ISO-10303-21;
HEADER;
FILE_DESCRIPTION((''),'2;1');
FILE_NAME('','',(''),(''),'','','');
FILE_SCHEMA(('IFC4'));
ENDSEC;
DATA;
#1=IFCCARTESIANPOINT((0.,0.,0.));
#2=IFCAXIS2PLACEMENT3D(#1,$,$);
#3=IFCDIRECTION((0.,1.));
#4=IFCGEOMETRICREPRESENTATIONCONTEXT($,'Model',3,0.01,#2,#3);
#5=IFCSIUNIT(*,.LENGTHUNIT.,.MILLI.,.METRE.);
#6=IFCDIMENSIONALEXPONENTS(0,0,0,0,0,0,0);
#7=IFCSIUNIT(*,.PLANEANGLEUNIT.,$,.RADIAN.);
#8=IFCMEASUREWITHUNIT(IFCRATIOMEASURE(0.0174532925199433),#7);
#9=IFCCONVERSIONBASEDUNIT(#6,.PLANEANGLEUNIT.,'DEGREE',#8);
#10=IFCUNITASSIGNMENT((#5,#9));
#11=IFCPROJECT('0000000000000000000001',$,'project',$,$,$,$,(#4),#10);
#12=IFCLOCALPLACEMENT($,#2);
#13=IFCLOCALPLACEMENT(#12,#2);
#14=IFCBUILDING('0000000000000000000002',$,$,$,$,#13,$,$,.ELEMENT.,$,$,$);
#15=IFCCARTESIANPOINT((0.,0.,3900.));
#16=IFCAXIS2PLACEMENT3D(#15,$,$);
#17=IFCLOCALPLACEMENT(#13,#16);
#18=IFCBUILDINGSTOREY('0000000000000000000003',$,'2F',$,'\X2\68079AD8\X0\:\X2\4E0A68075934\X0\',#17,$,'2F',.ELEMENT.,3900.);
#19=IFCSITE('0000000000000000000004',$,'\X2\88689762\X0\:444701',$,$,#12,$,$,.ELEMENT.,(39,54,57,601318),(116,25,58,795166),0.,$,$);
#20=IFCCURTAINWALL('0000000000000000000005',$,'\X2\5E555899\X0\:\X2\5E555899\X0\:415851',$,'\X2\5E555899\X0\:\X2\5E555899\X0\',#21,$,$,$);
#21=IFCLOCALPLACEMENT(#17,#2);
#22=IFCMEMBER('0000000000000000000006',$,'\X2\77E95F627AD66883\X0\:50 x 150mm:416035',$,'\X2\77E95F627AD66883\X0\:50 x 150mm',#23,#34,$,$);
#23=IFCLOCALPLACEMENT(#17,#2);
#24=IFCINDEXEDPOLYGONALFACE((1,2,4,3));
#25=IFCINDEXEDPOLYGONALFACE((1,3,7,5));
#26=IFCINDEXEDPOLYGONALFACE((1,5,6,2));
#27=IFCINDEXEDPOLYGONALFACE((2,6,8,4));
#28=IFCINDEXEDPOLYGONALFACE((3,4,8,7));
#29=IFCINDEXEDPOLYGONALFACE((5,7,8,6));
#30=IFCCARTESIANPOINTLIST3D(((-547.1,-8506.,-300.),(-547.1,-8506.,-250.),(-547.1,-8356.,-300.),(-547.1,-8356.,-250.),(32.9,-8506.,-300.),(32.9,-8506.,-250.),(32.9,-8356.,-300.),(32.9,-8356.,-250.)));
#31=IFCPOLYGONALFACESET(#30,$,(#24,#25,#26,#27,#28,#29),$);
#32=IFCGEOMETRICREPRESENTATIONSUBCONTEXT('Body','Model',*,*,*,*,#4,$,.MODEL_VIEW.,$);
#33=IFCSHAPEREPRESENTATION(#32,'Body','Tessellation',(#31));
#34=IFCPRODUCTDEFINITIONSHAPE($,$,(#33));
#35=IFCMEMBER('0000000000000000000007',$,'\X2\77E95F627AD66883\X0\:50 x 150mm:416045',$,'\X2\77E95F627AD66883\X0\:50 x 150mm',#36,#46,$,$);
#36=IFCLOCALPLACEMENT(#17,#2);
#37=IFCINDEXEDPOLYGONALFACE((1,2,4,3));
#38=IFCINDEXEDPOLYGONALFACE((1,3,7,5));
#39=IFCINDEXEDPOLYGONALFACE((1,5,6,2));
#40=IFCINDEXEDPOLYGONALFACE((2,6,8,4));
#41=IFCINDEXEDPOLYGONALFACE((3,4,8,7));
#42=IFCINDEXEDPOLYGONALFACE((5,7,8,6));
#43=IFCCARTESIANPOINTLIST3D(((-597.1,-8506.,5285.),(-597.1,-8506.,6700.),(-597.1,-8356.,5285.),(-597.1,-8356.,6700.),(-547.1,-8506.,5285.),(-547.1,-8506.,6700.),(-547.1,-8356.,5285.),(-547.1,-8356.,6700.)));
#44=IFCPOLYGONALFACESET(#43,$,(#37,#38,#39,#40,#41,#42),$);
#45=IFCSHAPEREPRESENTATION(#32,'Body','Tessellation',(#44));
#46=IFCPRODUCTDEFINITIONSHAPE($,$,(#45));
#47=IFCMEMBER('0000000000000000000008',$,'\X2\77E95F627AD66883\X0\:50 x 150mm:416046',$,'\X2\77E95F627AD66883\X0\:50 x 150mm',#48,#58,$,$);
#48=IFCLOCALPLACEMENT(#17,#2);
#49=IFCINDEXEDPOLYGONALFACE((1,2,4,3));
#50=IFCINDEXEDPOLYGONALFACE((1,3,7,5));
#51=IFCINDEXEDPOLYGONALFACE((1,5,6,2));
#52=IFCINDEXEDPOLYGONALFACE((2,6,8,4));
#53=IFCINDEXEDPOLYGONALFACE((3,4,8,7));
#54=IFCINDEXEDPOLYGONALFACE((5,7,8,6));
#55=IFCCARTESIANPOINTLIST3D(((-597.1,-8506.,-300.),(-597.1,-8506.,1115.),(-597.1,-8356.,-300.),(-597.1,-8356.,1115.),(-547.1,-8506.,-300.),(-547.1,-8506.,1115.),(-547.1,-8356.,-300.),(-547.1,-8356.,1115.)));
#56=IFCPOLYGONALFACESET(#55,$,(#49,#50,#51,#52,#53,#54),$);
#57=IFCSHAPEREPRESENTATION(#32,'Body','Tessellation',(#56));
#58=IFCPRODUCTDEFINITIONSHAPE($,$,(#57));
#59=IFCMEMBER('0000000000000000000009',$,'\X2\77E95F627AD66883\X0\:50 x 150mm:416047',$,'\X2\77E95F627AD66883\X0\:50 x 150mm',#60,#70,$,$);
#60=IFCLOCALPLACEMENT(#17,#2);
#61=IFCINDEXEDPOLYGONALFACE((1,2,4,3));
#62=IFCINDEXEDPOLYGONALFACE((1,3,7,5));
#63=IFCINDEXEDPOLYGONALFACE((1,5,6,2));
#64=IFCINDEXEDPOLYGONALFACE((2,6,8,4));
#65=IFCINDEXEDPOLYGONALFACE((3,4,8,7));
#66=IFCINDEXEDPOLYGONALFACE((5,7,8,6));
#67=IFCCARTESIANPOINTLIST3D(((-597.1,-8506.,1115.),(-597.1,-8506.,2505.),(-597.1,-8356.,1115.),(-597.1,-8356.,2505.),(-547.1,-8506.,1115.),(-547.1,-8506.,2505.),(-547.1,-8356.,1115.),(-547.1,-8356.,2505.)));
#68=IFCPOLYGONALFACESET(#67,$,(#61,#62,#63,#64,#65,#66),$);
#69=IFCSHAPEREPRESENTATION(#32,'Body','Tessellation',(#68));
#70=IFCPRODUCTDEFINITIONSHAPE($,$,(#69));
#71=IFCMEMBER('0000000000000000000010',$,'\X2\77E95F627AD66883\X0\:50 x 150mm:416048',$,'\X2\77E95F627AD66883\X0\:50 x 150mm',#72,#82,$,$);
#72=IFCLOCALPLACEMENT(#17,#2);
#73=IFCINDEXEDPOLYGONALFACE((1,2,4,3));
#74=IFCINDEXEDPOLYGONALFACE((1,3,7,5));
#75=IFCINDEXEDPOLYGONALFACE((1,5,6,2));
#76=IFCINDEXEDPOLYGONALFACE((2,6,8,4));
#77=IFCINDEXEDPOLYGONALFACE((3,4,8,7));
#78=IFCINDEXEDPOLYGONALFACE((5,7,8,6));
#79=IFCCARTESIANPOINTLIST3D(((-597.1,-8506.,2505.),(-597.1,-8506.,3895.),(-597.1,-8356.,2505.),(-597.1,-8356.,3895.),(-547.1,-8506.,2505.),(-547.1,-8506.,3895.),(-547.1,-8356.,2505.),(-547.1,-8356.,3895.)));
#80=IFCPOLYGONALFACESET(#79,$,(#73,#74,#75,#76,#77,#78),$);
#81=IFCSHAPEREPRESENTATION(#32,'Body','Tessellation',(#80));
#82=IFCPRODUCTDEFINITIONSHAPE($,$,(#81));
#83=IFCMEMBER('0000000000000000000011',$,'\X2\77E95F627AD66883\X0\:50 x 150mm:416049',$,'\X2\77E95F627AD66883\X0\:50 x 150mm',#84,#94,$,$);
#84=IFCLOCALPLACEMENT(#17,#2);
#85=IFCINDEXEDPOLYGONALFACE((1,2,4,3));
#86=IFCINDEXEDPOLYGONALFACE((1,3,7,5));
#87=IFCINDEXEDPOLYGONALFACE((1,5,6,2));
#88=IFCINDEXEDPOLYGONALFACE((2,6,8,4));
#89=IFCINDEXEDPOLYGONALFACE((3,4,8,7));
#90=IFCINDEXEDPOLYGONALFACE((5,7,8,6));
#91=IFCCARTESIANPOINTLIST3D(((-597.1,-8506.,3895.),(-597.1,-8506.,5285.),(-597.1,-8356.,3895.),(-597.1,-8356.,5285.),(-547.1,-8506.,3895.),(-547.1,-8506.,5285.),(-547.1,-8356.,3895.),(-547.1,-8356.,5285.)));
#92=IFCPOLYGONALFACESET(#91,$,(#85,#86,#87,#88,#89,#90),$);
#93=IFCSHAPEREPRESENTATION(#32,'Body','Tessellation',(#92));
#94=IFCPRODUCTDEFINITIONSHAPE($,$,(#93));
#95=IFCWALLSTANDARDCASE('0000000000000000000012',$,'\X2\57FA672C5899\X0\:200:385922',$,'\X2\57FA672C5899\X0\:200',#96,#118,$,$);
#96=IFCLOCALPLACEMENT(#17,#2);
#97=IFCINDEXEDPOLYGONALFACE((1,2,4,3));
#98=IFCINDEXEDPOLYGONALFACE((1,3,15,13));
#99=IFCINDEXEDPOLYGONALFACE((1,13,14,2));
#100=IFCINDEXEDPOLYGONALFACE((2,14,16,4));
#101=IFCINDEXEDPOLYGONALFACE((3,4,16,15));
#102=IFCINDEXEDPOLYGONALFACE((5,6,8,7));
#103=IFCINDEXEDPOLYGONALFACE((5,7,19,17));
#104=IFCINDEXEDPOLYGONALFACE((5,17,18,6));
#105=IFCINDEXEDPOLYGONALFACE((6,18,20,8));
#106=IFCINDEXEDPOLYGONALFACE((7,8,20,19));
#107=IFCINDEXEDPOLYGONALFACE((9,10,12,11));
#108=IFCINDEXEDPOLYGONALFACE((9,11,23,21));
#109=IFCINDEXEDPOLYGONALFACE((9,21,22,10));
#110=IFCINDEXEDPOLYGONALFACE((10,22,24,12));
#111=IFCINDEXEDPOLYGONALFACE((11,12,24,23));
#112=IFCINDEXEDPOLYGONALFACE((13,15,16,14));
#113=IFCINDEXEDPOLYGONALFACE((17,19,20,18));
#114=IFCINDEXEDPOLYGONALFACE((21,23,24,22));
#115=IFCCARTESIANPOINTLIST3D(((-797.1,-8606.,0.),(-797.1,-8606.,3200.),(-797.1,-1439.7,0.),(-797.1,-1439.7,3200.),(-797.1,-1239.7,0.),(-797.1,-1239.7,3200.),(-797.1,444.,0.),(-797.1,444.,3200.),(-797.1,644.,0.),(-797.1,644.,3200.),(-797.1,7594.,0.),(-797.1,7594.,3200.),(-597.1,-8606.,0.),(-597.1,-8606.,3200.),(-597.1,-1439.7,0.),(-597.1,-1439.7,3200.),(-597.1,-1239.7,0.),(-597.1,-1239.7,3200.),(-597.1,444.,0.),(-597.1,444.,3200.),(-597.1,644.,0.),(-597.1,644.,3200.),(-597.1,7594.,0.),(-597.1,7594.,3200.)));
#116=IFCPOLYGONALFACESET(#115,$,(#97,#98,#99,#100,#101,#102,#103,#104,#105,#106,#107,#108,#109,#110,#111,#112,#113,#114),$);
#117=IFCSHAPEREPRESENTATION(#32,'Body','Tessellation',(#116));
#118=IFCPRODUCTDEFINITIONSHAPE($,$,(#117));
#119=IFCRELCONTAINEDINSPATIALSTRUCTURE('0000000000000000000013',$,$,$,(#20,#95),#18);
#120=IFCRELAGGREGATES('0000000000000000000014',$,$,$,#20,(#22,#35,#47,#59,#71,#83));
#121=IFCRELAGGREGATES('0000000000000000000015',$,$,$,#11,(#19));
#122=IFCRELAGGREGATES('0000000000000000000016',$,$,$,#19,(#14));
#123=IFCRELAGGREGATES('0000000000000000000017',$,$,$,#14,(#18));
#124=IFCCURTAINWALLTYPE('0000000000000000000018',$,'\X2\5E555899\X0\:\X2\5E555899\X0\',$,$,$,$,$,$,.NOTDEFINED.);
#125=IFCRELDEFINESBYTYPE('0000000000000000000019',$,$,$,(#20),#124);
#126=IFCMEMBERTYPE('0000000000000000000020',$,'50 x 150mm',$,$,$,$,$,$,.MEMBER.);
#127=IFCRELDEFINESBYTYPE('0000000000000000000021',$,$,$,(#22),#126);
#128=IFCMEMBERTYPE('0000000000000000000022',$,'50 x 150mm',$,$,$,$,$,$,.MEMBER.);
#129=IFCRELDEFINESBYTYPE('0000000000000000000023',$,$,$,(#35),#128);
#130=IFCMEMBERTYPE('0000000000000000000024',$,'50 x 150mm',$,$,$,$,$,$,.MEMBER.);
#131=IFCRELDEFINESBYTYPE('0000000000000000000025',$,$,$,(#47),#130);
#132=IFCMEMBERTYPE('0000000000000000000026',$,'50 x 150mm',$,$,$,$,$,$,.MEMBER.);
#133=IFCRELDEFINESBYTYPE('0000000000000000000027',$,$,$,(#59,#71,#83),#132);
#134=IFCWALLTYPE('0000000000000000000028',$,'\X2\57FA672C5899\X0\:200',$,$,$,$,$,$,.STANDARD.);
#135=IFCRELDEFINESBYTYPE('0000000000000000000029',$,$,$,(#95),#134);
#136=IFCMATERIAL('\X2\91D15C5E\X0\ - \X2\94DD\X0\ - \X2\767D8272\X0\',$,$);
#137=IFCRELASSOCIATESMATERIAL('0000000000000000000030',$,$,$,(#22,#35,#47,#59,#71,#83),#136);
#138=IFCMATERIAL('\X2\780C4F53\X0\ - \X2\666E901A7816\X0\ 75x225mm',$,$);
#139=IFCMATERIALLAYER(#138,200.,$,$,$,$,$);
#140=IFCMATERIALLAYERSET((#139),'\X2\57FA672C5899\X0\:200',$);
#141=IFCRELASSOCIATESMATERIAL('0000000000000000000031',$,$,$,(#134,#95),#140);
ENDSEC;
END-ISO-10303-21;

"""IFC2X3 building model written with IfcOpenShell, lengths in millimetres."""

from ifc_helpers import new_model, entity, si_unit, converted_unit, direction, frame, frame_2d, origin, origin_2d_with_axis, place, context, subcontext, project, spatial, rectangle, extrude, source, transform, mapped, material, layer, layer_set, layer_usage, type_object, type_shapes, element, aggregate, save


model = new_model("IFC2X3")

# Units and contexts
model_context = context("Model", 3, precision=0.01, world=origin(), true_north=direction((0.0, 1.0)))
body_context = subcontext(model_context, "Body", "Model", "MODEL_VIEW")
ifc_project = project(units=[si_unit("LENGTHUNIT", "METRE", prefix="MILLI"), converted_unit("PLANEANGLEUNIT", "DEGREE", entity("IfcRatioMeasure", 0.0174532925199433), si_unit("PLANEANGLEUNIT", "RADIAN"), dimensions=[0, 0, 0, 0, 0, 0, 0])], contexts=[model_context])

# Site, building, storey
site_placement = place(None, origin())
site = spatial("IfcSite", under=ifc_project, at=site_placement, Name="表面:444701", CompositionType="ELEMENT", RefLatitude=(39, 54, 57, 601318), RefLongitude=(116, 25, 58, 795166), RefElevation=0.0)
building_placement = place(site_placement, origin())
building = spatial("IfcBuilding", under=site, at=building_placement, CompositionType="ELEMENT")
storey_placement = place(building_placement, frame((0.0, 0.0, 3900.0)))
storey = spatial("IfcBuildingStorey", under=building, at=storey_placement, Name="2F", ObjectType="标高:上标头", LongName="2F", CompositionType="ELEMENT", Elevation=3900.0)

# Curtain wall, member
curtain_wall_type = type_object("IfcCurtainWallType", Name="幕墙:幕墙", PredefinedType="NOTDEFINED")
curtain_wall_1_placement = place(storey_placement, frame((0.0, 0.0, -3900.0)))
curtain_wall_1 = element("IfcCurtainWall", 1, at=curtain_wall_1_placement, inside=storey, type_object=curtain_wall_type, Name="幕墙:幕墙:415851", ObjectType="幕墙:幕墙")
ifc_material_1 = material(Name="金属 - 铝 - 白色")
member_type_1 = type_object("IfcMemberType", Name="50 x 150mm", PredefinedType="MEMBER")
shared_shape_1 = source(origin(), body_context, "Body", "SweptSolid", [
    extrude(rectangle(XDim=150.0, YDim=50.0, at=origin_2d_with_axis()), frame((-25.0, 0.0, -580.0), z_axis=(0.0, 0.0, 1.0), x_axis=(0.0, -1.0, 0.0)), (0.0, 0.0, 1.0), 580.0),
])
type_shapes(member_type_1, [shared_shape_1])
member_1_placement = place(storey_placement, frame((-547.1, -8431.0, -300.0), z_axis=(-1.0, 0.0, 0.0), x_axis=(0.0, 0.0, -1.0)))
member_1 = element("IfcMember", 2, at=member_1_placement, type_object=member_type_1, material=ifc_material_1, Name="矩形竖梃:50 x 150mm:416035", ObjectType="矩形竖梃:50 x 150mm", context=body_context, shape_type="MappedRepresentation", body=[
    mapped(shared_shape_1, transform((0.0, 0.0, 0.0), scale=1.0)),
])

# Members
member_type_2 = type_object("IfcMemberType", Name="50 x 150mm", PredefinedType="MEMBER")
shared_shape_2 = source(origin(), body_context, "Body", "SweptSolid", [
    extrude(rectangle(XDim=150.0, YDim=50.0, at=origin_2d_with_axis()), frame((-25.0, 0.0, -1415.0), z_axis=(0.0, 0.0, 1.0), x_axis=(0.0, -1.0, 0.0)), (0.0, 0.0, 1.0), 1415.0),
])
type_shapes(member_type_2, [shared_shape_2])
member_2_placement = place(storey_placement, frame((-597.1, -8431.0, 6700.0), z_axis=(0.0, 0.0, 1.0), x_axis=(-1.0, 0.0, 0.0)))
member_2 = element("IfcMember", 3, at=member_2_placement, type_object=member_type_2, material=ifc_material_1, Name="矩形竖梃:50 x 150mm:416045", ObjectType="矩形竖梃:50 x 150mm", context=body_context, shape_type="MappedRepresentation", body=[
    mapped(shared_shape_2, transform((0.0, 0.0, 0.0), scale=1.0)),
])
member_type_3 = type_object("IfcMemberType", Name="50 x 150mm", PredefinedType="MEMBER")
shared_shape_3 = source(origin(), body_context, "Body", "SweptSolid", [
    extrude(rectangle(XDim=150.0, YDim=50.0, at=origin_2d_with_axis()), frame((-25.0, 0.0, -1415.0), z_axis=(0.0, 0.0, 1.0), x_axis=(0.0, -1.0, 0.0)), (0.0, 0.0, 1.0), 1415.0),
])
type_shapes(member_type_3, [shared_shape_3])
member_3_placement = place(storey_placement, frame((-597.1, -8431.0, 1115.0), z_axis=(0.0, 0.0, 1.0), x_axis=(-1.0, 0.0, 0.0)))
member_3 = element("IfcMember", 4, at=member_3_placement, type_object=member_type_3, material=ifc_material_1, Name="矩形竖梃:50 x 150mm:416046", ObjectType="矩形竖梃:50 x 150mm", context=body_context, shape_type="MappedRepresentation", body=[
    mapped(shared_shape_3, transform((0.0, 0.0, 0.0), scale=1.0)),
])
member_type_4 = type_object("IfcMemberType", Name="50 x 150mm", PredefinedType="MEMBER")
shared_shape_4 = source(origin(), body_context, "Body", "SweptSolid", [
    extrude(rectangle(XDim=150.0, YDim=50.0, at=origin_2d_with_axis()), frame((-25.0, 0.0, -1390.0), z_axis=(0.0, 0.0, 1.0), x_axis=(0.0, -1.0, 0.0)), (0.0, 0.0, 1.0), 1390.0),
])
type_shapes(member_type_4, [shared_shape_4])
member_4_placement = place(storey_placement, frame((-597.1, -8431.0, 2505.0), z_axis=(0.0, 0.0, 1.0), x_axis=(-1.0, 0.0, 0.0)))
member_4 = element("IfcMember", 5, at=member_4_placement, type_object=member_type_4, material=ifc_material_1, Name="矩形竖梃:50 x 150mm:416047", ObjectType="矩形竖梃:50 x 150mm", context=body_context, shape_type="MappedRepresentation", body=[
    mapped(shared_shape_4, transform((0.0, 0.0, 0.0), scale=1.0)),
])
member_5_placement = place(storey_placement, frame((-597.1, -8431.0, 3895.0), z_axis=(0.0, 0.0, 1.0), x_axis=(-1.0, 0.0, 0.0)))
member_5 = element("IfcMember", 6, at=member_5_placement, type_object=member_type_4, material=ifc_material_1, Name="矩形竖梃:50 x 150mm:416048", ObjectType="矩形竖梃:50 x 150mm", context=body_context, shape_type="MappedRepresentation", body=[
    mapped(shared_shape_4, transform((0.0, 0.0, 0.0), scale=1.0)),
])
member_6_placement = place(storey_placement, frame((-597.1, -8431.0, 5285.0), z_axis=(0.0, 0.0, 1.0), x_axis=(-1.0, 0.0, 0.0)))
member_6 = element("IfcMember", 7, at=member_6_placement, type_object=member_type_4, material=ifc_material_1, Name="矩形竖梃:50 x 150mm:416049", ObjectType="矩形竖梃:50 x 150mm", context=body_context, shape_type="MappedRepresentation", body=[
    mapped(shared_shape_4, transform((0.0, 0.0, 0.0), scale=1.0)),
])

aggregate(curtain_wall_1, [member_1, member_2, member_3, member_4, member_5, member_6])

# Shared definitions
ifc_material_2 = material(Name="砌体 - 普通砖 75x225mm")

# Wall, openings
ifc_layer_1 = layer(ifc_material_2, 200.0)
ifc_layer_set_1 = layer_set([ifc_layer_1], Name="基本墙:200")
ifc_layer_usage_1 = layer_usage(ifc_layer_set_1, "AXIS2", "NEGATIVE", 100.0)
wall_type_1 = type_object("IfcWallType", Name="基本墙:200", PredefinedType="STANDARD", material=ifc_layer_set_1)
wall_1_placement = place(storey_placement, frame((-697.1, -8606.0, 0.0), z_axis=(0.0, 0.0, 1.0), x_axis=(0.0, 1.0, 0.0)))
wall_1 = element("IfcWallStandardCase", 8, at=wall_1_placement, inside=storey, type_object=wall_type_1, material=ifc_layer_usage_1, Name="基本墙:200:385922", ObjectType="基本墙:200", context=body_context, shape_type="SweptSolid", body=[
    extrude(rectangle(XDim=16200.0, YDim=200.0, at=frame_2d((8100.0, 0.0), x_axis=(-1.0, 0.0))), origin(), (0.0, 0.0, 1.0), 3200.0),
])
opening_1_placement = place(storey_placement, frame((-697.1, -8606.0, 0.0), z_axis=(0.0, 0.0, 1.0), x_axis=(0.0, 1.0, 0.0)))
element("IfcOpeningElement", 9, at=opening_1_placement, cuts=wall_1, ObjectType="Opening", context=body_context, shape_type="SweptSolid", body=[
    extrude(rectangle(XDim=3200.0, YDim=200.0, at=origin_2d_with_axis()), frame((9050.0, 0.0, 1600.0), z_axis=(1.0, 0.0, 0.0), x_axis=(0.0, 0.0, -1.0)), (0.0, 0.0, 1.0), 200.0),
])
opening_2_placement = place(storey_placement, frame((-697.1, -8606.0, 0.0), z_axis=(0.0, 0.0, 1.0), x_axis=(0.0, 1.0, 0.0)))
element("IfcOpeningElement", 10, at=opening_2_placement, cuts=wall_1, ObjectType="Opening", context=body_context, shape_type="SweptSolid", body=[
    extrude(rectangle(XDim=3200.0, YDim=200.0, at=frame_2d((0.0, 0.0), x_axis=(1.0, 0.0))), frame((7166.3, 0.0, 1600.0), z_axis=(1.0, 0.0, 0.0), x_axis=(0.0, 0.0, -1.0)), (0.0, 0.0, 1.0), 200.0),
])

save(model, "model.ifc")
